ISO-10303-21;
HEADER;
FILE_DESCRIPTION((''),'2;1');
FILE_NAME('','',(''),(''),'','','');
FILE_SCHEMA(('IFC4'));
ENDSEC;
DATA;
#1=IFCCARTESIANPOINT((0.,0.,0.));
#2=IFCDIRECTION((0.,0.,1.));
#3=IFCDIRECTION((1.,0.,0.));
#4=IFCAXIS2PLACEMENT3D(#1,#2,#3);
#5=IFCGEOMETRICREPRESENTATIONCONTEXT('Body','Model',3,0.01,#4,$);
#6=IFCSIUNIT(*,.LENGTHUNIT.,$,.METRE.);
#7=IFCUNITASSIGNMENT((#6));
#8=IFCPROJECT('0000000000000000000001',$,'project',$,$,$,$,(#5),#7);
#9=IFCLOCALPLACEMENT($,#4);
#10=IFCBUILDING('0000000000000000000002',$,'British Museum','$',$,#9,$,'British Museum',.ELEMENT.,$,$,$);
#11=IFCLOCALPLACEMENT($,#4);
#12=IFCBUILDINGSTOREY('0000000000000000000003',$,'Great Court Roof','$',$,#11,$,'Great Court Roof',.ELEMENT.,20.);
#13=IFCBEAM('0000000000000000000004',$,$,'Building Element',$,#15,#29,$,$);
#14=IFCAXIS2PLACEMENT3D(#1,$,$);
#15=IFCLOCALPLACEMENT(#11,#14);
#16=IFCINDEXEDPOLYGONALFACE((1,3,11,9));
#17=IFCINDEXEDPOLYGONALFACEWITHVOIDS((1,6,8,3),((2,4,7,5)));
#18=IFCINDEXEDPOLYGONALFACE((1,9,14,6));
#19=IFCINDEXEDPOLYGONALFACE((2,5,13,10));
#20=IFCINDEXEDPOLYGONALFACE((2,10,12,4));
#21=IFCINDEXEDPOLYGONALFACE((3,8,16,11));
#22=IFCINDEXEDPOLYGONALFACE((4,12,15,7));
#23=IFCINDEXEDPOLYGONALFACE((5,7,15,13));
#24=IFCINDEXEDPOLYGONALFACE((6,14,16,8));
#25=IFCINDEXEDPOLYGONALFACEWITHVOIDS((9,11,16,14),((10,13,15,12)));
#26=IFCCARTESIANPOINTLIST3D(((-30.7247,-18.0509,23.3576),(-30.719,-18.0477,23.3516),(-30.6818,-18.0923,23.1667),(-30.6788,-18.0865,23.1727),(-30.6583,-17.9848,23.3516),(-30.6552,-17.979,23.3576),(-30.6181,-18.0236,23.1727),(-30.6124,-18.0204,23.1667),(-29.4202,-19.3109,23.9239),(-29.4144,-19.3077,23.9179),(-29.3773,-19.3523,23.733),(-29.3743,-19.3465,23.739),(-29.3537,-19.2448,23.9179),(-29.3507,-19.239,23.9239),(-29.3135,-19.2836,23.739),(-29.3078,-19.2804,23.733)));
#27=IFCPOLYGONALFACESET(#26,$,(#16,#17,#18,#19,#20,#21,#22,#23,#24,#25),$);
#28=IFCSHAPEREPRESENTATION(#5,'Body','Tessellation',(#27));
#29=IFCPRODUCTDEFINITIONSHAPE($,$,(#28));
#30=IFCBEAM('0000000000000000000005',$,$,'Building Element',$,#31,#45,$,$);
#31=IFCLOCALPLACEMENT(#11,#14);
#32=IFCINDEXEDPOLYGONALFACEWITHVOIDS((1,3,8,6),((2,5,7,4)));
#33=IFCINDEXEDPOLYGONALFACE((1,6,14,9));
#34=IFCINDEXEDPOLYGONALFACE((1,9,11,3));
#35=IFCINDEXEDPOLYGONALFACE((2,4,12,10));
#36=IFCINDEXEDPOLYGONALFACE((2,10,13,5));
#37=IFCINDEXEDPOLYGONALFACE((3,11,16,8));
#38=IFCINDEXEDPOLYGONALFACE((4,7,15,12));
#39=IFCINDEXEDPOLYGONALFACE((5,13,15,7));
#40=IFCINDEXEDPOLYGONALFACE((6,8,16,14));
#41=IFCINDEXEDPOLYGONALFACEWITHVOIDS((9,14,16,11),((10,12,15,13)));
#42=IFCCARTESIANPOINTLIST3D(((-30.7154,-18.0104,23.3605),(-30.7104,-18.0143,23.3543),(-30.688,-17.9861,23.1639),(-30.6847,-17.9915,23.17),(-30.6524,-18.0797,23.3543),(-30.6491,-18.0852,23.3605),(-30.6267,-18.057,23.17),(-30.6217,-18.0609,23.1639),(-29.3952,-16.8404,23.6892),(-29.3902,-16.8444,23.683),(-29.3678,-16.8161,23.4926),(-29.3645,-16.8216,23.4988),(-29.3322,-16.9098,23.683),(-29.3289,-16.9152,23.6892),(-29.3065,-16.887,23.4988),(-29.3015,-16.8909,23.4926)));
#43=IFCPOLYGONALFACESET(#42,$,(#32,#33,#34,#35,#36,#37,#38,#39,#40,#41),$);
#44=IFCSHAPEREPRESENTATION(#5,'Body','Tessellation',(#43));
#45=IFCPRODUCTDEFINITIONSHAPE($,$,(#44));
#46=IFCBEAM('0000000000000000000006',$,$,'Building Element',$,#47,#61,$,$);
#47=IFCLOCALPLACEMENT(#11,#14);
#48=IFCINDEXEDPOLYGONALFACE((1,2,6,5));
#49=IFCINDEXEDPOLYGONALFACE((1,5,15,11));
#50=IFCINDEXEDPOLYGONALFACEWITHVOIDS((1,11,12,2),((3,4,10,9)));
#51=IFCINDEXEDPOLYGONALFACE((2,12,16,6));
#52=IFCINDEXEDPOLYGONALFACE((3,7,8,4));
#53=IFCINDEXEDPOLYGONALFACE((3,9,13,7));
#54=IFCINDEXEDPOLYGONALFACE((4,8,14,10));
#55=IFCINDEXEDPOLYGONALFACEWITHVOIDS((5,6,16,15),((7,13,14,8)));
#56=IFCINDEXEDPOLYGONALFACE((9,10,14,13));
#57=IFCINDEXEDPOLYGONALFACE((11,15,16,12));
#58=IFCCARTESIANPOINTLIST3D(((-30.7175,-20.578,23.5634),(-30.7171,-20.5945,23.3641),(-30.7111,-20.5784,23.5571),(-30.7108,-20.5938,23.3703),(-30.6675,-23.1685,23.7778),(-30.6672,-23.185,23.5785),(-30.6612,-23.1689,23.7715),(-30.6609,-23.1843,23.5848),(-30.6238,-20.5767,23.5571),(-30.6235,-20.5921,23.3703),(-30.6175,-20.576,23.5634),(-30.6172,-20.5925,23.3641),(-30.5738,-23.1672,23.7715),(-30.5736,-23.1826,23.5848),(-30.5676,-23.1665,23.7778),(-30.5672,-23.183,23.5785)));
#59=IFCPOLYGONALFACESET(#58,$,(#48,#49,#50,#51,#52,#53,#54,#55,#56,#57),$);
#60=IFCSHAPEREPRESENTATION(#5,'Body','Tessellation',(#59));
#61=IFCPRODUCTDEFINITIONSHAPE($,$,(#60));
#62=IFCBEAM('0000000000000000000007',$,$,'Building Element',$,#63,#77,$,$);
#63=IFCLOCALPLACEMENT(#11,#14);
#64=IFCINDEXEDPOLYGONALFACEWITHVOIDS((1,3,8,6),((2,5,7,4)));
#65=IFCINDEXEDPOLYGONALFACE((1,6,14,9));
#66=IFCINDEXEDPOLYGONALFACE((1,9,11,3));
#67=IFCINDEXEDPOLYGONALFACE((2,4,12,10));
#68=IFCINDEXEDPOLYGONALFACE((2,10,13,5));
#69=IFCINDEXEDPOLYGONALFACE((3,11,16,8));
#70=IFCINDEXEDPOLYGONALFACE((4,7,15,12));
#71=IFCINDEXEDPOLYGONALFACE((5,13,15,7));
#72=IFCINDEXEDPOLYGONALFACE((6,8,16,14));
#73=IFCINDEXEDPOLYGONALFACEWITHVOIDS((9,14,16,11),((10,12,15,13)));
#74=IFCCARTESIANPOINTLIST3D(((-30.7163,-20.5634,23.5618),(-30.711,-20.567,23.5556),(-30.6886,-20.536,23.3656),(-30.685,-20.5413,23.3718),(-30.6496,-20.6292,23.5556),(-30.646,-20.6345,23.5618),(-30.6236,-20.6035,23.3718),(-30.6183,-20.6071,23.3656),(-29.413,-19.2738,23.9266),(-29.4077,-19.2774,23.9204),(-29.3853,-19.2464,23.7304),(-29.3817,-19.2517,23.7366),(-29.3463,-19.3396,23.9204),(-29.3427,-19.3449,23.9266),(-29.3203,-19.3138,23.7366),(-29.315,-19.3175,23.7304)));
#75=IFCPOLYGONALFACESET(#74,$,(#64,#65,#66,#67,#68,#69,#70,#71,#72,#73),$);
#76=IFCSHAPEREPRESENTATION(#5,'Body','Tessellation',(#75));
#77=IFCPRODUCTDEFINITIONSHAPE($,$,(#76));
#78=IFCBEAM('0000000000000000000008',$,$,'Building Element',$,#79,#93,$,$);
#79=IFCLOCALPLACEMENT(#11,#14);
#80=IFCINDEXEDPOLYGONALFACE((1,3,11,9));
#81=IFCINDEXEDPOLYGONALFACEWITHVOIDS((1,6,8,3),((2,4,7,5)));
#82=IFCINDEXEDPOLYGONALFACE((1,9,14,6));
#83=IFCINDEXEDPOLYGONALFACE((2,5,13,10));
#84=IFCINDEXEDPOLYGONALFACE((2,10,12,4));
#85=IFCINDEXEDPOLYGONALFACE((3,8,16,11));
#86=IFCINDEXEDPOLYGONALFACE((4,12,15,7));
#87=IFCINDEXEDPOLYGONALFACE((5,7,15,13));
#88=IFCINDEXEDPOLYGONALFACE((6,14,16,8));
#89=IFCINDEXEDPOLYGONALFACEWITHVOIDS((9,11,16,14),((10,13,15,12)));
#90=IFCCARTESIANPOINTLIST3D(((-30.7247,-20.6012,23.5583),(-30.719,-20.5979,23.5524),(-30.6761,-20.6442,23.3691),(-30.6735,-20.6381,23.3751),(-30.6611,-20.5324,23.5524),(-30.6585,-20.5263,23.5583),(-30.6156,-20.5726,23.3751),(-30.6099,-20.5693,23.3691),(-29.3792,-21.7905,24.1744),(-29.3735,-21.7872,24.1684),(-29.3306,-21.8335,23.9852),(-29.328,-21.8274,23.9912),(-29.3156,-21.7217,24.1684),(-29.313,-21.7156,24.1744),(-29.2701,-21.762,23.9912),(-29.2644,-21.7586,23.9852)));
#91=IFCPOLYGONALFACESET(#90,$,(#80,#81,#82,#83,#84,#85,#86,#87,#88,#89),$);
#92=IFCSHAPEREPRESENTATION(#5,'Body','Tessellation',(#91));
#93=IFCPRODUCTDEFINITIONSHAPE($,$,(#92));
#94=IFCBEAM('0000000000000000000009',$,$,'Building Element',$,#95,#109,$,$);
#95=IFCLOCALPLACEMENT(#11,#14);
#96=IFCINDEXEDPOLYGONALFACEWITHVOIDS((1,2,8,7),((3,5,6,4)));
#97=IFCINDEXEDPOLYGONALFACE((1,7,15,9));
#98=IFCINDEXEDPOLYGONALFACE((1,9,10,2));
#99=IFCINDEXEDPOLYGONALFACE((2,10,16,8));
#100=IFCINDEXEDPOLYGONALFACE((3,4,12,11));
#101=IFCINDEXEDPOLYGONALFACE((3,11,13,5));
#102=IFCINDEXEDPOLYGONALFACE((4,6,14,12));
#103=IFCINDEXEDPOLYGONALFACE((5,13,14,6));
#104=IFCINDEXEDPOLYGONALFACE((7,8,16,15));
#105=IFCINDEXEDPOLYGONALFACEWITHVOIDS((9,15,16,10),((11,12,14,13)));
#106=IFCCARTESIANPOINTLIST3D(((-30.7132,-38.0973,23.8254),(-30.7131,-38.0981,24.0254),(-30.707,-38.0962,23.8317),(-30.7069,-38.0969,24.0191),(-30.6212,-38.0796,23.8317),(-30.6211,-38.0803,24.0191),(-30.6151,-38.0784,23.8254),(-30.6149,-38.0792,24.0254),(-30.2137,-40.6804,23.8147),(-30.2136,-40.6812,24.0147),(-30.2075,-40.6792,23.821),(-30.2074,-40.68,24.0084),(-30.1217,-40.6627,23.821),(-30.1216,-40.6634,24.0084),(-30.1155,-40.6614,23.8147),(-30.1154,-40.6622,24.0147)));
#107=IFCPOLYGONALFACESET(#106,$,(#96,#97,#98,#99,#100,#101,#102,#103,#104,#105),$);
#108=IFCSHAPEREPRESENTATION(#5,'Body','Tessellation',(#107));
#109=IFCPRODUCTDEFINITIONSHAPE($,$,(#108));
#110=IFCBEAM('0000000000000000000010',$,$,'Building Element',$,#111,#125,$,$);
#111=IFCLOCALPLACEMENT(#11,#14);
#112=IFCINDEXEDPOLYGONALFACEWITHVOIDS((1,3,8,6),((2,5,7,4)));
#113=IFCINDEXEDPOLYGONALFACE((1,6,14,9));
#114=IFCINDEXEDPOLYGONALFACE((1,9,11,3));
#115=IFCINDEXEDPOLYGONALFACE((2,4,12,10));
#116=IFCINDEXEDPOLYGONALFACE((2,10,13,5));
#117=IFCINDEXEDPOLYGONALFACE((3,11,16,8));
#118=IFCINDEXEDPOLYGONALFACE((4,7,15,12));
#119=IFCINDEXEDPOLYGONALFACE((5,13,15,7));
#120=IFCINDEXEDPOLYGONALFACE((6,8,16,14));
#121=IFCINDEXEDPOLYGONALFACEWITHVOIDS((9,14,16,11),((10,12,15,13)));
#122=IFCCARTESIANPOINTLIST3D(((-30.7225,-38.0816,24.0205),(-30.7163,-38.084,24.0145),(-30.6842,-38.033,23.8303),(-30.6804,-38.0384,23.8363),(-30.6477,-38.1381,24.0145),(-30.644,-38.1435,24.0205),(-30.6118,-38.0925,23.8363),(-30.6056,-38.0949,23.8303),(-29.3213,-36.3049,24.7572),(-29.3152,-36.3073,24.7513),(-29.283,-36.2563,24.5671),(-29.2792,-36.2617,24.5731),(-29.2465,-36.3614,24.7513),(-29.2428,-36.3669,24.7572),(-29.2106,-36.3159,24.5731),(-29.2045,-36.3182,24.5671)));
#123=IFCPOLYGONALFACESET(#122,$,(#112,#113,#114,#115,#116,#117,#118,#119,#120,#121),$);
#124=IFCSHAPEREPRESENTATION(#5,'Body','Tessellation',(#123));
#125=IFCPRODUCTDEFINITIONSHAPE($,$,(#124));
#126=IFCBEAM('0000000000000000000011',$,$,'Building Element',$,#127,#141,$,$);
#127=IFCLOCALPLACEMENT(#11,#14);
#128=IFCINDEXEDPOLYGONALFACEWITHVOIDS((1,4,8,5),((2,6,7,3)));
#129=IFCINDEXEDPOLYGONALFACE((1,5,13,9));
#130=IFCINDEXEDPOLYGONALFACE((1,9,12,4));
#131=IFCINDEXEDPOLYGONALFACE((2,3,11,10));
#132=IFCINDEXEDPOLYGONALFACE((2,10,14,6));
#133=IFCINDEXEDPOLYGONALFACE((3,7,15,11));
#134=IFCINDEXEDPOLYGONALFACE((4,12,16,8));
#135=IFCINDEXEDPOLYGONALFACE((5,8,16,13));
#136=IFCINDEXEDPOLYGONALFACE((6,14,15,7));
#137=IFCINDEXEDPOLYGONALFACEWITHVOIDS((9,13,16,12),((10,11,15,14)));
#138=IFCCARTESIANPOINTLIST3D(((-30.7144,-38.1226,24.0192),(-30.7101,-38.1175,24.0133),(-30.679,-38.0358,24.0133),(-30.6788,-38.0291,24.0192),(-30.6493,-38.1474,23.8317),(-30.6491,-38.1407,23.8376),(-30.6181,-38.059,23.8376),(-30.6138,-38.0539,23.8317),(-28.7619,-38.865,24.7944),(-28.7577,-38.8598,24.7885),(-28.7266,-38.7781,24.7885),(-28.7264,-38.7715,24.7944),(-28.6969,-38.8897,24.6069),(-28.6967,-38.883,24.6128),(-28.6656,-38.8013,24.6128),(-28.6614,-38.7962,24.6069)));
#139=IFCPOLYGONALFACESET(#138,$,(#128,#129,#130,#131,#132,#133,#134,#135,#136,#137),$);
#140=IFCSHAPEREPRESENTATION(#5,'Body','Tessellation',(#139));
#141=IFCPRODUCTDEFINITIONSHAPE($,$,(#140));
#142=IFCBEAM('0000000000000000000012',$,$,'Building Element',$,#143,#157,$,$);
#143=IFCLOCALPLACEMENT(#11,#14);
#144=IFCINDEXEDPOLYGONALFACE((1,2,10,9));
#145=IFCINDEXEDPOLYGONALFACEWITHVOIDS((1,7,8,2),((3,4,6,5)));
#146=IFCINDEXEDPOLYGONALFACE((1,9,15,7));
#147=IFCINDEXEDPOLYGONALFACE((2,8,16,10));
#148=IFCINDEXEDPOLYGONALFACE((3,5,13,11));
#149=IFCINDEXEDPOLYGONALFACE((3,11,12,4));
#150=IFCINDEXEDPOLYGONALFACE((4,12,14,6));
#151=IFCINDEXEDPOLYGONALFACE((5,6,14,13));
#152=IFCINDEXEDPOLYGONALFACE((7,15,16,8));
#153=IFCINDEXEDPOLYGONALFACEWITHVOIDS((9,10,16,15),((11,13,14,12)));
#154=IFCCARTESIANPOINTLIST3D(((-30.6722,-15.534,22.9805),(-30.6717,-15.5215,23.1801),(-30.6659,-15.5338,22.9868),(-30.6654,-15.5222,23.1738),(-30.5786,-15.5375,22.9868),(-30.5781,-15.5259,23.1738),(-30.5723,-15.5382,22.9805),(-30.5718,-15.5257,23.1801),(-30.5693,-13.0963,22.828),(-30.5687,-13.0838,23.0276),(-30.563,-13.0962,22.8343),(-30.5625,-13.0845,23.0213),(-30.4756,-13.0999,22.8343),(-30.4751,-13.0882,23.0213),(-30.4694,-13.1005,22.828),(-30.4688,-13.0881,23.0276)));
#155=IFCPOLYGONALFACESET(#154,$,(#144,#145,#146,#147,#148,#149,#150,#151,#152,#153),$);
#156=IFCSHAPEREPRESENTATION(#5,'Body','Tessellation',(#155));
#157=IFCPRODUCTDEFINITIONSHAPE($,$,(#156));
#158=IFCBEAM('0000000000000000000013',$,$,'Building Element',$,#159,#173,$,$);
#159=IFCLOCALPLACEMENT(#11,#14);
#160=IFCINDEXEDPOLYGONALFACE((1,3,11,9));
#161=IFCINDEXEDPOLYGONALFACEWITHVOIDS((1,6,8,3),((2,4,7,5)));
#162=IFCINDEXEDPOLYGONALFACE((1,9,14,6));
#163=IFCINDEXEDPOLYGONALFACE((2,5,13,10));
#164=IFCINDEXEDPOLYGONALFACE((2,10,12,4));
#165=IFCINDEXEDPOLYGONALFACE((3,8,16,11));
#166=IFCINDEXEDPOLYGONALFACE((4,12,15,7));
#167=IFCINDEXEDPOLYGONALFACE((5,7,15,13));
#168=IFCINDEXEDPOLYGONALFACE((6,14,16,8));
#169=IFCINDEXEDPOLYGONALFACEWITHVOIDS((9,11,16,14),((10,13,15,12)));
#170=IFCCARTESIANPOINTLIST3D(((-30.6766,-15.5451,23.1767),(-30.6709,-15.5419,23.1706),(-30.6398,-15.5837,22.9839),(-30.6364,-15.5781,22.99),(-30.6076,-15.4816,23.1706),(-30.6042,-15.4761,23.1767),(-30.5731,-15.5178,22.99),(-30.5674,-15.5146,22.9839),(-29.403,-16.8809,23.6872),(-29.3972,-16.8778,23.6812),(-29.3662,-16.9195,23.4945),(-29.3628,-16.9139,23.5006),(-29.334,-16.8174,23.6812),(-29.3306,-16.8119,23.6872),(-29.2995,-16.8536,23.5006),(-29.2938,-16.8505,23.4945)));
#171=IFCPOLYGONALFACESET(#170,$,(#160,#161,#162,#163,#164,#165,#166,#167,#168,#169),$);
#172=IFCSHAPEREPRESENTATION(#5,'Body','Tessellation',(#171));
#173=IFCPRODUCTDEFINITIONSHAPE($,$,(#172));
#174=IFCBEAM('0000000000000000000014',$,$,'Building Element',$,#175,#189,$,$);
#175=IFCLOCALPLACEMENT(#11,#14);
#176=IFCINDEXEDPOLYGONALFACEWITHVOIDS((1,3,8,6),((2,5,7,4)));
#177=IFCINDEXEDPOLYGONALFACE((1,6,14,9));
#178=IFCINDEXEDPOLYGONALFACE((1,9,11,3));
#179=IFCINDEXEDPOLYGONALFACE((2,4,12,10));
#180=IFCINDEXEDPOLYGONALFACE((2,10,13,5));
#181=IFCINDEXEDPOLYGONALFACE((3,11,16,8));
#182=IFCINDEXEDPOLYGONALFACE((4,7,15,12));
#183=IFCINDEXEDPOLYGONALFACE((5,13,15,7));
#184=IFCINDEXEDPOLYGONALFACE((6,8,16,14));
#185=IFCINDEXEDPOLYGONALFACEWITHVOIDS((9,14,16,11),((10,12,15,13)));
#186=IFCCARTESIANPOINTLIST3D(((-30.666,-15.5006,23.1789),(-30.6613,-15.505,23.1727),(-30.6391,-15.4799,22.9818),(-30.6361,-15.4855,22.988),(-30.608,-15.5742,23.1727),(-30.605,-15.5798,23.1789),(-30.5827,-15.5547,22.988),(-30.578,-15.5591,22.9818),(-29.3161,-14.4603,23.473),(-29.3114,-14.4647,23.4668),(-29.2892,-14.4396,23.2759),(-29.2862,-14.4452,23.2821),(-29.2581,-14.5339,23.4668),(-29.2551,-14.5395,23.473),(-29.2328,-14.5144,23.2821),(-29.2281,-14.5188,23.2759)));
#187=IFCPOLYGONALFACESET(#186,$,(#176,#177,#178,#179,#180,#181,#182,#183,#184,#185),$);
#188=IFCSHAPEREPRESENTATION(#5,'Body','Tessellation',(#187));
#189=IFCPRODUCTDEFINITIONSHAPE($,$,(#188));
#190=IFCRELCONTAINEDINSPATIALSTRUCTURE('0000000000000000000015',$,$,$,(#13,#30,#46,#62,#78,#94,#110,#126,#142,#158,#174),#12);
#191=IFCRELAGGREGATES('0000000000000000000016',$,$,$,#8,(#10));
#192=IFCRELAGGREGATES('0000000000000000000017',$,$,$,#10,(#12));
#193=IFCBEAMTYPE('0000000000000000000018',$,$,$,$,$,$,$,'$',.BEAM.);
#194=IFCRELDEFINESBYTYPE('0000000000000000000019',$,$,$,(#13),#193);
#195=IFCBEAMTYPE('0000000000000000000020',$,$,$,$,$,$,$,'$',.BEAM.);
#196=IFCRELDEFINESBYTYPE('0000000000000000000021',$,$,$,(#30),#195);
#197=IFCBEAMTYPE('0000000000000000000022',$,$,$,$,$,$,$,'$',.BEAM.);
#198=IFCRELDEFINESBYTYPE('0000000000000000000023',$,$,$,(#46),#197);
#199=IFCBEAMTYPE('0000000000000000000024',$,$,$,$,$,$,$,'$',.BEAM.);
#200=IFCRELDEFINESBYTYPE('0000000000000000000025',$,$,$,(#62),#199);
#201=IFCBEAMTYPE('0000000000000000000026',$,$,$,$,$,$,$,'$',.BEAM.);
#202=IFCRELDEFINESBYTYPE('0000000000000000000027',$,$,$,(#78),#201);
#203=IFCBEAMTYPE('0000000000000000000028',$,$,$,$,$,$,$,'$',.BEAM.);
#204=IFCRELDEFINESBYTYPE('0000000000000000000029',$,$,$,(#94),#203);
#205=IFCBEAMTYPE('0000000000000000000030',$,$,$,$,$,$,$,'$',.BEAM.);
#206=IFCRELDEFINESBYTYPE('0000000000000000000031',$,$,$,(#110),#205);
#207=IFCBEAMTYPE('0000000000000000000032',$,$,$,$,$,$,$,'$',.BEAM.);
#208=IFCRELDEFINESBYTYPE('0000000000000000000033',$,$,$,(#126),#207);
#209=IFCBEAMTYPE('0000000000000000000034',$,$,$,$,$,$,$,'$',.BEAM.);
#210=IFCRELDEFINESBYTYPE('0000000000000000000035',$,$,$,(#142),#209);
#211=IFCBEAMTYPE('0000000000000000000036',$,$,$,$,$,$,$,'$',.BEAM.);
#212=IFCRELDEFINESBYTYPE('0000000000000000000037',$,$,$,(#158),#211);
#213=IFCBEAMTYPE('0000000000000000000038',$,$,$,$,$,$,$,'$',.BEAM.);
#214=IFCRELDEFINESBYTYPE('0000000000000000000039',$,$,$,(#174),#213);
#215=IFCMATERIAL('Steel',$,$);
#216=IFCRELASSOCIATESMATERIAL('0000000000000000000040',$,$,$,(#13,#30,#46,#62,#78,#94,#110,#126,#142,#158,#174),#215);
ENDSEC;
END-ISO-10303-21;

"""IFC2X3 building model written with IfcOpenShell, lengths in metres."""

from ifc_helpers import new_model, si_unit, frame, origin_with_axes, origin_2d, place, context, project, spatial, hollow_rectangle, extrude, material, type_object, element, save


model = new_model("IFC2X3")

# Units and contexts
model_context = context("Model", 3, precision=0.01, world=origin_with_axes(), identifier="Body")
ifc_project = project(units=[si_unit("LENGTHUNIT", "METRE")], contexts=[model_context])

# Building, storey
building_placement = place(None, origin_with_axes())
building = spatial("IfcBuilding", under=ifc_project, at=building_placement, Name="British Museum", Description="$", LongName="British Museum", CompositionType="ELEMENT")
storey_placement = place(None, origin_with_axes())
storey = spatial("IfcBuildingStorey", under=building, at=storey_placement, Name="Great Court Roof", Description="$", LongName="Great Court Roof", CompositionType="ELEMENT", Elevation=20.0)

# Beams
ifc_material = material(Name="Steel")
beam_type_1 = type_object("IfcBeamType", ElementType="$", PredefinedType="BEAM")
beam_1_placement = place(None, origin_with_axes())
element("IfcBeam", 1, at=beam_1_placement, inside=storey, type_object=beam_type_1, material=ifc_material, Description="Building Element", context=model_context, shape_type="SweptSolid", body=[
    extrude(hollow_rectangle(XDim=0.1, YDim=0.2, WallThickness=0.0063, InnerFilletRadius=0.0, OuterFilletRadius=0.0, at=origin_2d()), frame((-30.6685, -18.0356, 23.2622), z_axis=(0.686584, -0.663148, 0.298056), x_axis=(0.694724, 0.719276, 0.0)), (0.0, 0.0, 1.0), 1.9),
])
beam_type_2 = type_object("IfcBeamType", ElementType="$", PredefinedType="BEAM")
beam_2_placement = place(None, origin_with_axes())
element("IfcBeam", 2, at=beam_2_placement, inside=storey, type_object=beam_type_2, material=ifc_material, Description="Building Element", context=model_context, shape_type="SweptSolid", body=[
    extrude(hollow_rectangle(XDim=0.1, YDim=0.2, WallThickness=0.0063, InnerFilletRadius=0.0, OuterFilletRadius=0.0, at=origin_2d()), frame((-30.6685, -18.0356, 23.2622), z_axis=(0.735732, 0.652028, 0.183191), x_axis=(-0.663252, 0.748396, 0.0)), (0.0, 0.0, 1.0), 1.7943),
])
beam_type_3 = type_object("IfcBeamType", ElementType="$", PredefinedType="BEAM")
beam_3_placement = place(None, origin_with_axes())
element("IfcBeam", 3, at=beam_3_placement, inside=storey, type_object=beam_type_3, material=ifc_material, Description="Building Element", context=model_context, shape_type="SweptSolid", body=[
    extrude(hollow_rectangle(XDim=0.1, YDim=0.2, WallThickness=0.0063, InnerFilletRadius=0.0, OuterFilletRadius=0.0, at=origin_2d()), frame((-30.6673, -20.5853, 23.4637), z_axis=(0.019198, -0.996408, 0.082481), x_axis=(0.999814, 0.019264, 0.0)), (0.0, 0.0, 1.0), 2.5998),
])
beam_type_4 = type_object("IfcBeamType", ElementType="$", PredefinedType="BEAM")
beam_4_placement = place(None, origin_with_axes())
element("IfcBeam", 4, at=beam_4_placement, inside=storey, type_object=beam_type_4, material=ifc_material, Description="Building Element", context=model_context, shape_type="SweptSolid", body=[
    extrude(hollow_rectangle(XDim=0.1, YDim=0.2, WallThickness=0.0063, InnerFilletRadius=0.0, OuterFilletRadius=0.0, at=origin_2d()), frame((-30.6673, -20.5853, 23.4637), z_axis=(0.69717, 0.689843, 0.195116), x_axis=(-0.703361, 0.710832, 0.0)), (0.0, 0.0, 1.0), 1.8694),
])
beam_type_5 = type_object("IfcBeamType", ElementType="$", PredefinedType="BEAM")
beam_5_placement = place(None, origin_with_axes())
element("IfcBeam", 5, at=beam_5_placement, inside=storey, type_object=beam_type_5, material=ifc_material, Description="Building Element", context=model_context, shape_type="SweptSolid", body=[
    extrude(hollow_rectangle(XDim=0.1, YDim=0.2, WallThickness=0.0063, InnerFilletRadius=0.0, OuterFilletRadius=0.0, at=origin_2d()), frame((-30.6673, -20.5853, 23.4637), z_axis=(0.708712, -0.626435, 0.324508), x_axis=(0.662276, 0.74926, 0.0)), (0.0, 0.0, 1.0), 1.8985),
])
beam_type_6 = type_object("IfcBeamType", ElementType="$", PredefinedType="BEAM")
beam_6_placement = place(None, origin_with_axes())
element("IfcBeam", 6, at=beam_6_placement, inside=storey, type_object=beam_type_6, material=ifc_material, Description="Building Element", context=model_context, shape_type="SweptSolid", body=[
    extrude(hollow_rectangle(XDim=0.1, YDim=0.2, WallThickness=0.0063, InnerFilletRadius=0.0, OuterFilletRadius=0.0, at=origin_2d()), frame((-30.6641, -38.0882, 23.9254), z_axis=(0.18986, -0.981803, -0.004061), x_axis=(0.981811, 0.189862, 0.0)), (0.0, 0.0, 1.0), 2.631),
])
beam_type_7 = type_object("IfcBeamType", ElementType="$", PredefinedType="BEAM")
beam_7_placement = place(None, origin_with_axes())
element("IfcBeam", 7, at=beam_7_placement, inside=storey, type_object=beam_type_7, material=ifc_material, Description="Building Element", context=model_context, shape_type="SweptSolid", body=[
    extrude(hollow_rectangle(XDim=0.1, YDim=0.2, WallThickness=0.0063, InnerFilletRadius=0.0, OuterFilletRadius=0.0, at=origin_2d()), frame((-30.6641, -38.0882, 23.9254), z_axis=(0.588824, 0.746614, 0.309602), x_axis=(-0.785194, 0.61925, 0.0)), (0.0, 0.0, 1.0), 2.3796),
])
beam_type_8 = type_object("IfcBeamType", ElementType="$", PredefinedType="BEAM")
beam_8_placement = place(None, origin_with_axes())
element("IfcBeam", 8, at=beam_8_placement, inside=storey, type_object=beam_type_8, material=ifc_material, Description="Building Element", context=model_context, shape_type="SweptSolid", body=[
    extrude(hollow_rectangle(XDim=0.1, YDim=0.2, WallThickness=0.0063, InnerFilletRadius=0.0, OuterFilletRadius=0.0, at=origin_2d()), frame((-30.6641, -38.0882, 23.9254), z_axis=(0.876313, -0.333184, 0.347943), x_axis=(0.35539, 0.934718, 0.0)), (0.0, 0.0, 1.0), 2.228),
])
beam_type_9 = type_object("IfcBeamType", ElementType="$", PredefinedType="BEAM")
beam_9_placement = place(None, origin_with_axes())
element("IfcBeam", 9, at=beam_9_placement, inside=storey, type_object=beam_type_9, material=ifc_material, Description="Building Element", context=model_context, shape_type="SweptSolid", body=[
    extrude(hollow_rectangle(XDim=0.1, YDim=0.2, WallThickness=0.0063, InnerFilletRadius=0.0, OuterFilletRadius=0.0, at=origin_2d()), frame((-30.622, -15.5299, 23.0803), z_axis=(0.042115, 0.997164, -0.062379), x_axis=(-0.999109, 0.042197, 0.0)), (0.0, 0.0, 1.0), 2.4446),
])
beam_type_10 = type_object("IfcBeamType", ElementType="$", PredefinedType="BEAM")
beam_10_placement = place(None, origin_with_axes())
element("IfcBeam", 10, at=beam_10_placement, inside=storey, type_object=beam_type_10, material=ifc_material, Description="Building Element", context=model_context, shape_type="SweptSolid", body=[
    extrude(hollow_rectangle(XDim=0.1, YDim=0.2, WallThickness=0.0063, InnerFilletRadius=0.0, OuterFilletRadius=0.0, at=origin_2d()), frame((-30.622, -15.5299, 23.0803), z_axis=(0.665084, -0.697557, 0.266604), x_axis=(0.723752, 0.69006, 0.0)), (0.0, 0.0, 1.0), 1.915),
])
beam_type_11 = type_object("IfcBeamType", ElementType="$", PredefinedType="BEAM")
beam_11_placement = place(None, origin_with_axes())
element("IfcBeam", 11, at=beam_11_placement, inside=storey, type_object=beam_type_11, material=ifc_material, Description="Building Element", context=model_context, shape_type="SweptSolid", body=[
    extrude(hollow_rectangle(XDim=0.1, YDim=0.2, WallThickness=0.0063, InnerFilletRadius=0.0, OuterFilletRadius=0.0, at=origin_2d()), frame((-30.622, -15.5299, 23.0803), z_axis=(0.780536, 0.601532, 0.170069), x_axis=(-0.610425, 0.792074, 0.0)), (0.0, 0.0, 1.0), 1.7294),
])

save(model, "model.ifc")
